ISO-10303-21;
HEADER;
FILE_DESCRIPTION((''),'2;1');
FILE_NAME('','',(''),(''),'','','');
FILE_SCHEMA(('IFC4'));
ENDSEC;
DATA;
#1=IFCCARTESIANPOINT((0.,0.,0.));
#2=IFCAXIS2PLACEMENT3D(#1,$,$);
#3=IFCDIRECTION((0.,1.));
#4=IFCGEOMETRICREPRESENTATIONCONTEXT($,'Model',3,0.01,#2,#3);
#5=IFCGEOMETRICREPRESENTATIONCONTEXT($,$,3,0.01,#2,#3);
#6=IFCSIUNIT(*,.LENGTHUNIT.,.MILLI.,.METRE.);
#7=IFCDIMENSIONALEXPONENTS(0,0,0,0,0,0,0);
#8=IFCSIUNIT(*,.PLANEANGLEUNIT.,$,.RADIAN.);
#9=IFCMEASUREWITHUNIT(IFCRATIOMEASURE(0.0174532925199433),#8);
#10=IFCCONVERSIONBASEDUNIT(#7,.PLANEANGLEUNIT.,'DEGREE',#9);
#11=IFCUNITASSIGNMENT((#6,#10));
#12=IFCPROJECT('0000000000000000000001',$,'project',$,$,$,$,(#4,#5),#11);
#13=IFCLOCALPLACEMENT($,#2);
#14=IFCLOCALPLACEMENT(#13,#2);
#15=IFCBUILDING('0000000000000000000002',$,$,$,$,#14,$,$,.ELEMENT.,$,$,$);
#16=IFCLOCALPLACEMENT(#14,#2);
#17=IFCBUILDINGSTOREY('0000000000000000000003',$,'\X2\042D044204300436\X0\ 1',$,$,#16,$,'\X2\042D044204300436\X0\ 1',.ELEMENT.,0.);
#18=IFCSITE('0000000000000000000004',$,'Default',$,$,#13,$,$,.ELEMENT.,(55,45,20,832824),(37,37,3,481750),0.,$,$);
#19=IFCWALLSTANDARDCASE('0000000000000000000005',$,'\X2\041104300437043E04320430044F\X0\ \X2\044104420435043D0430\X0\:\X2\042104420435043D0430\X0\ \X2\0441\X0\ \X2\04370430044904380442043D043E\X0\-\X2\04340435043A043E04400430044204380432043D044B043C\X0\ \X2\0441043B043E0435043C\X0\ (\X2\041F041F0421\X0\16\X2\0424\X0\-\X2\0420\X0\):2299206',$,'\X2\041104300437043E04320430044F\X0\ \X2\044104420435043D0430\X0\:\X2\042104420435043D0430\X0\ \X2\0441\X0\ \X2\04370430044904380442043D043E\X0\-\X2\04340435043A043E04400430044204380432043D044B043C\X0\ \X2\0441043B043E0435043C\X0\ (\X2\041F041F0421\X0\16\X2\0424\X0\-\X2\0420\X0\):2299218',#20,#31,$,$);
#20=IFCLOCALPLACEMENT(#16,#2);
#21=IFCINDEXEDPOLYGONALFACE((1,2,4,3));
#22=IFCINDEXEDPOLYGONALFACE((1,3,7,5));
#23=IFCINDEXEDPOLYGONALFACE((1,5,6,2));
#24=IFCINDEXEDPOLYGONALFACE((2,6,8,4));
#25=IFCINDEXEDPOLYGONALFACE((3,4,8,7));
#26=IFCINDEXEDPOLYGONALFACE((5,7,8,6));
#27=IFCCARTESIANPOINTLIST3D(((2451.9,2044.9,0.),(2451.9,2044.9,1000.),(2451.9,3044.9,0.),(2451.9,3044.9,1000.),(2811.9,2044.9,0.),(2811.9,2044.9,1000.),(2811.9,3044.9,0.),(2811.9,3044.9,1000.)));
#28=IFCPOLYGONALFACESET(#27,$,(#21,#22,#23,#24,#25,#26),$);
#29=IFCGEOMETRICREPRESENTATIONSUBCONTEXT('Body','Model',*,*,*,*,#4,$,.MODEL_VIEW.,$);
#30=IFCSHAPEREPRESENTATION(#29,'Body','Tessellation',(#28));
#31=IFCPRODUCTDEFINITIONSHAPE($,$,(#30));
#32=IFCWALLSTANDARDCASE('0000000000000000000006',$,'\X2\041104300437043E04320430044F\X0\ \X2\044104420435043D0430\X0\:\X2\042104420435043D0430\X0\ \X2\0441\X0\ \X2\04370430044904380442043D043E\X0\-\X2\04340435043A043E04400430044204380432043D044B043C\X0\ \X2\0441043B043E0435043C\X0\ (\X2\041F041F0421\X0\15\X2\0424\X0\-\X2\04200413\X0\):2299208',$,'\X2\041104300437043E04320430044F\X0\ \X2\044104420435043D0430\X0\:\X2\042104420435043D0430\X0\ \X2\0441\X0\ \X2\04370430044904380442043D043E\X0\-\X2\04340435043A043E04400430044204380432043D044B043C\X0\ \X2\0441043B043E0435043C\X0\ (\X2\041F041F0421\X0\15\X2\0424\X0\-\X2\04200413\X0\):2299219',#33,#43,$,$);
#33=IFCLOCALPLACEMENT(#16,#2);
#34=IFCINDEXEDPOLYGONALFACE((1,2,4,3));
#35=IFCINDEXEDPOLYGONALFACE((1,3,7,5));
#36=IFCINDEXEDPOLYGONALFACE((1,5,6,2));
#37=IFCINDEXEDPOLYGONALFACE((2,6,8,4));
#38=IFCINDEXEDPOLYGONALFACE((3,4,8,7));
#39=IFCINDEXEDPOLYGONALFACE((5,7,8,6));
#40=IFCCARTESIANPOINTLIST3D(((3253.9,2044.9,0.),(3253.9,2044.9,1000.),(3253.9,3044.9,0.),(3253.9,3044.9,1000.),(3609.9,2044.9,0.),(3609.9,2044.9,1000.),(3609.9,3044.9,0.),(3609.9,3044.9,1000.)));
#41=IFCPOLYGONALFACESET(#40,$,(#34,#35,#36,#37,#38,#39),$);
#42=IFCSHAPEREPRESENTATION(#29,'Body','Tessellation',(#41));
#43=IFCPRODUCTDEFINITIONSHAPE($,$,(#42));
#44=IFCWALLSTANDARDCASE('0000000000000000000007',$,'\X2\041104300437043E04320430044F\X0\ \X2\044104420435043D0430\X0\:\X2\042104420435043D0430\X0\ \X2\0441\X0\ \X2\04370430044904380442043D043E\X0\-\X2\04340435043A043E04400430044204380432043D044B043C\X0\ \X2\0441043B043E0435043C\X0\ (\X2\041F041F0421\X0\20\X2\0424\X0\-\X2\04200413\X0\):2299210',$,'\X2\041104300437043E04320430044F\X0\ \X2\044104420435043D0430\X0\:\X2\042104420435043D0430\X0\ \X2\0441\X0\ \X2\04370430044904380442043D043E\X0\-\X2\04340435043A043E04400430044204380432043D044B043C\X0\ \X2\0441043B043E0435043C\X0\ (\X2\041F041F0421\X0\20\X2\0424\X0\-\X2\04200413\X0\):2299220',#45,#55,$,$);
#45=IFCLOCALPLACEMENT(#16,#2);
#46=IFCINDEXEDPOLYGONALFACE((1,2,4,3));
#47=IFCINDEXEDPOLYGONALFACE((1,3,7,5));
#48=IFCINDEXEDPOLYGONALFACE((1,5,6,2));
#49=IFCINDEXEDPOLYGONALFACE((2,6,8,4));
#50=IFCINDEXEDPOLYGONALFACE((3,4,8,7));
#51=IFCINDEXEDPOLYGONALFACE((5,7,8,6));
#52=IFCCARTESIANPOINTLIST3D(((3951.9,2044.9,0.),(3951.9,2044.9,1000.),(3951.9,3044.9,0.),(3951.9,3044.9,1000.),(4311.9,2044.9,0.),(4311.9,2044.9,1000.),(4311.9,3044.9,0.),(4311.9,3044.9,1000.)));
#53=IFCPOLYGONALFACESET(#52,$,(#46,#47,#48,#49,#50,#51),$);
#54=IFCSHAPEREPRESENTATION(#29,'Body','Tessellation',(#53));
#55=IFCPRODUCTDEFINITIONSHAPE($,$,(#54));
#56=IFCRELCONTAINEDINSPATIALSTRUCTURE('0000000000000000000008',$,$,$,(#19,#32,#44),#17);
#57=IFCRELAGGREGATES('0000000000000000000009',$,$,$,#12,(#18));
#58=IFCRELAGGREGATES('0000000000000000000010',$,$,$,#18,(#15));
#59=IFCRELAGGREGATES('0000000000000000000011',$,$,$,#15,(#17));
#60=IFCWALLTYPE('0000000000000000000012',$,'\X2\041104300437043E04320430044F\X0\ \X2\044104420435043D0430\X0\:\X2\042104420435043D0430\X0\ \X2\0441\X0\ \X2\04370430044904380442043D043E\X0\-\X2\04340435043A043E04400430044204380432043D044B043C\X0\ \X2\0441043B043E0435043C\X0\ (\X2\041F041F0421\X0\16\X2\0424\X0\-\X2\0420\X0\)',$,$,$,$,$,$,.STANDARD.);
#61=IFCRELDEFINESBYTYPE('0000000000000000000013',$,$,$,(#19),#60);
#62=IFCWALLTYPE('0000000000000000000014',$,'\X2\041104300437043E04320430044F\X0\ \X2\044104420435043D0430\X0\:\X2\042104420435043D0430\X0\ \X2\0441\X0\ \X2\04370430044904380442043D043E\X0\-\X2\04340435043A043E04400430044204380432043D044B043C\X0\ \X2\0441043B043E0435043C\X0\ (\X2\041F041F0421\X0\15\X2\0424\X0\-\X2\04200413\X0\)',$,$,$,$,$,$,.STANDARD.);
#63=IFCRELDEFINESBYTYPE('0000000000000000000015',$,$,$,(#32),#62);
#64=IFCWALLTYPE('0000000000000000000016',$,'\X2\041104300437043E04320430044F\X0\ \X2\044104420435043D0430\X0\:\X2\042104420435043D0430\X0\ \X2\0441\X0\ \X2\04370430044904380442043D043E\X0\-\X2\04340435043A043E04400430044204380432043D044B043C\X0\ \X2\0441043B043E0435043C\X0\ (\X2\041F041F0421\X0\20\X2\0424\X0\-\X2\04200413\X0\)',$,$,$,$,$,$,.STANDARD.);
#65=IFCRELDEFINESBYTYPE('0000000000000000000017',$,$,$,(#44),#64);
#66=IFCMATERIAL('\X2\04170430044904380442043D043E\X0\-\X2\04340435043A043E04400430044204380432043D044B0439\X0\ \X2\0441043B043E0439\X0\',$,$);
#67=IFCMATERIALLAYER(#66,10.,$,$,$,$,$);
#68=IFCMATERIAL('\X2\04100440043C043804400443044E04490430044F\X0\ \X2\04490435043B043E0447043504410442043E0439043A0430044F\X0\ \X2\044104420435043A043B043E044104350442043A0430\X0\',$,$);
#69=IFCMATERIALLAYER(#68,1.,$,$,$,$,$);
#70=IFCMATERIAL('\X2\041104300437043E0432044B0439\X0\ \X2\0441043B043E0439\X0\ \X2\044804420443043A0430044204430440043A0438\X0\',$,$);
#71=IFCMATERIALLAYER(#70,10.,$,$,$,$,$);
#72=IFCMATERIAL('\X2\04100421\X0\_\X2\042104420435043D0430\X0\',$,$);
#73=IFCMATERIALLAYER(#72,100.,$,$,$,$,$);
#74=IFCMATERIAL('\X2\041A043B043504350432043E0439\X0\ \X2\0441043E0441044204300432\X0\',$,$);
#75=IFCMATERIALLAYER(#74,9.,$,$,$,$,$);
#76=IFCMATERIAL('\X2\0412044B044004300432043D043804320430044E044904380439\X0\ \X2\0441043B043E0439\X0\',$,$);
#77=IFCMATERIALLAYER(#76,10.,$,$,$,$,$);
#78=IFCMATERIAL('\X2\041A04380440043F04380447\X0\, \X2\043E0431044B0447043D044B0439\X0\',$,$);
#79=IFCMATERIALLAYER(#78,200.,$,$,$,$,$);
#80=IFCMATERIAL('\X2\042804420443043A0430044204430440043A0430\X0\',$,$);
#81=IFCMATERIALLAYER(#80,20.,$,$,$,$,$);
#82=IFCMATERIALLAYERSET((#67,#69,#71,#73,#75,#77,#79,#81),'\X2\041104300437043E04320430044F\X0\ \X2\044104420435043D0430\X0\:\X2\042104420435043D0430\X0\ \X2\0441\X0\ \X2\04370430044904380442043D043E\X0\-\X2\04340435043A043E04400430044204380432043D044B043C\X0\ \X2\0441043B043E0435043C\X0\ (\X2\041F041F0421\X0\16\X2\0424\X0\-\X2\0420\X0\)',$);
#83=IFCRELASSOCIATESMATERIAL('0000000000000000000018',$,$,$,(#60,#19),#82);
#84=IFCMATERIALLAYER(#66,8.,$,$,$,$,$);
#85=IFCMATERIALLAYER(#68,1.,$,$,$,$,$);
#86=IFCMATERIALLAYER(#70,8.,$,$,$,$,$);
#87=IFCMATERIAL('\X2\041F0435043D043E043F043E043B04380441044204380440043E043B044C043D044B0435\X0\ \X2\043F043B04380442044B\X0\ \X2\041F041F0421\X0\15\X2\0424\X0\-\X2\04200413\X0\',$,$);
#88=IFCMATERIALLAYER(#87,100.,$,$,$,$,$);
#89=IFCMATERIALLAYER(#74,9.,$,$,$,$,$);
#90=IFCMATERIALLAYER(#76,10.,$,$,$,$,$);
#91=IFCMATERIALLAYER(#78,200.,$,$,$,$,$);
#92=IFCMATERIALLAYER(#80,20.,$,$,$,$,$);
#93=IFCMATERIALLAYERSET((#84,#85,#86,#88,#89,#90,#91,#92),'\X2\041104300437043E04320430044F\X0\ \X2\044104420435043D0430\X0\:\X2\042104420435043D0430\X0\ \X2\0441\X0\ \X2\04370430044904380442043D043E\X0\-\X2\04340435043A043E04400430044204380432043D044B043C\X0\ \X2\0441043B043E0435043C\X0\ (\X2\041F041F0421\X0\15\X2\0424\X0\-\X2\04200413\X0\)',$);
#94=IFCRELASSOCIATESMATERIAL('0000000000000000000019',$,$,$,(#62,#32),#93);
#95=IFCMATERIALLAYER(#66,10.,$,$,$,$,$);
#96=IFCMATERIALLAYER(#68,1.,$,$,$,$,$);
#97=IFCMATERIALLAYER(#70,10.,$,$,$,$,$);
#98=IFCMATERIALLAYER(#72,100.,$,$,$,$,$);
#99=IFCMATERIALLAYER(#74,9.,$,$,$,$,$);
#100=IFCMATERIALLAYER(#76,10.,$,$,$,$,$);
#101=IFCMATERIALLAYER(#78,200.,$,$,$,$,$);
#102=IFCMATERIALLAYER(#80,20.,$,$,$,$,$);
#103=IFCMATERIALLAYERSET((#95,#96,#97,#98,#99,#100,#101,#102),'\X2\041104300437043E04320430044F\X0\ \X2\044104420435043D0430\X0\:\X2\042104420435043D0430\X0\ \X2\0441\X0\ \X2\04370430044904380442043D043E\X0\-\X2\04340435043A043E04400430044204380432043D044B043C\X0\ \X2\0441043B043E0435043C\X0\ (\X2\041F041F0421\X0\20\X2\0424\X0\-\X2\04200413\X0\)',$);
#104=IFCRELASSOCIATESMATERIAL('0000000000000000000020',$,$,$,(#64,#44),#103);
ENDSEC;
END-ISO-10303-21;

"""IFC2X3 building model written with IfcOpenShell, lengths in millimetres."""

from ifc_helpers import new_model, entity, si_unit, converted_unit, direction, frame, frame_2d, origin, place, context, subcontext, project, spatial, rectangle, extrude, material, layer, layer_set, layer_usage, type_object, element, save


model = new_model("IFC2X3")

# Units and contexts
model_context = context("Model", 3, precision=0.01, world=origin(), true_north=direction((0.0, 1.0)))
context_of_model = context(None, 3, precision=0.01, world=origin(), true_north=direction((0.0, 1.0)))
body_context = subcontext(model_context, "Body", "Model", "MODEL_VIEW")
ifc_project = project(units=[si_unit("LENGTHUNIT", "METRE", prefix="MILLI"), converted_unit("PLANEANGLEUNIT", "DEGREE", entity("IfcRatioMeasure", 0.0174532925199433), si_unit("PLANEANGLEUNIT", "RADIAN"), dimensions=[0, 0, 0, 0, 0, 0, 0])], contexts=[model_context, context_of_model])

# Site, building, storey
site_placement = place(None, origin())
site = spatial("IfcSite", under=ifc_project, at=site_placement, Name="Default", CompositionType="ELEMENT", RefLatitude=(55, 45, 20, 832824), RefLongitude=(37, 37, 3, 481750), RefElevation=0.0)
building_placement = place(site_placement, origin())
building = spatial("IfcBuilding", under=site, at=building_placement, CompositionType="ELEMENT")
storey_placement = place(building_placement, origin())
storey = spatial("IfcBuildingStorey", under=building, at=storey_placement, Name="Этаж 1", LongName="Этаж 1", CompositionType="ELEMENT", Elevation=0.0)

# Walls
ifc_material_1 = material(Name="Защитно-декоративный слой")
ifc_layer_1 = layer(ifc_material_1, 10.0)
ifc_material_2 = material(Name="Армирующая щелочестойкая стеклосетка")
ifc_layer_2 = layer(ifc_material_2, 1.0)
ifc_material_3 = material(Name="Базовый слой штукатурки")
ifc_layer_3 = layer(ifc_material_3, 10.0)
ifc_material_4 = material(Name="АС_Стена")
ifc_layer_4 = layer(ifc_material_4, 100.0)
ifc_material_5 = material(Name="Клеевой состав")
ifc_layer_5 = layer(ifc_material_5, 9.0)
ifc_material_6 = material(Name="Выравнивающий слой")
ifc_layer_6 = layer(ifc_material_6, 10.0)
ifc_material_7 = material(Name="Кирпич, обычный")
ifc_layer_7 = layer(ifc_material_7, 200.0)
ifc_material_8 = material(Name="Штукатурка")
ifc_layer_8 = layer(ifc_material_8, 20.0)
ifc_layer_set_1 = layer_set([ifc_layer_1, ifc_layer_2, ifc_layer_3, ifc_layer_4, ifc_layer_5, ifc_layer_6, ifc_layer_7, ifc_layer_8], Name="Базовая стена:Стена с защитно-декоративным слоем (ППС16Ф-Р)")
ifc_layer_usage_1 = layer_usage(ifc_layer_set_1, "AXIS2", "POSITIVE", -180.0)
wall_type_1 = type_object("IfcWallType", Name="Базовая стена:Стена с защитно-декоративным слоем (ППС16Ф-Р)", PredefinedType="STANDARD", material=ifc_layer_set_1)
wall_1_placement = place(storey_placement, frame((2631.9, 3044.9, 0.0), z_axis=(0.0, 0.0, 1.0), x_axis=(0.0, -1.0, 0.0)))
element("IfcWallStandardCase", 1, at=wall_1_placement, inside=storey, type_object=wall_type_1, material=ifc_layer_usage_1, Name="Базовая стена:Стена с защитно-декоративным слоем (ППС16Ф-Р):2299206", ObjectType="Базовая стена:Стена с защитно-декоративным слоем (ППС16Ф-Р):2299218", context=body_context, shape_type="SweptSolid", body=[
    extrude(rectangle(XDim=1000.0, YDim=360.0, at=frame_2d((500.0, 0.0), x_axis=(-1.0, 0.0))), origin(), (0.0, 0.0, 1.0), 1000.0),
])
ifc_layer_9 = layer(ifc_material_1, 8.0)
ifc_layer_10 = layer(ifc_material_2, 1.0)
ifc_layer_11 = layer(ifc_material_3, 8.0)
ifc_material_9 = material(Name="Пенополистирольные плиты ППС15Ф-РГ")
ifc_layer_12 = layer(ifc_material_9, 100.0)
ifc_layer_13 = layer(ifc_material_5, 9.0)
ifc_layer_14 = layer(ifc_material_6, 10.0)
ifc_layer_15 = layer(ifc_material_7, 200.0)
ifc_layer_16 = layer(ifc_material_8, 20.0)
ifc_layer_set_2 = layer_set([ifc_layer_9, ifc_layer_10, ifc_layer_11, ifc_layer_12, ifc_layer_13, ifc_layer_14, ifc_layer_15, ifc_layer_16], Name="Базовая стена:Стена с защитно-декоративным слоем (ППС15Ф-РГ)")
ifc_layer_usage_2 = layer_usage(ifc_layer_set_2, "AXIS2", "POSITIVE", -178.0)
wall_type_2 = type_object("IfcWallType", Name="Базовая стена:Стена с защитно-декоративным слоем (ППС15Ф-РГ)", PredefinedType="STANDARD", material=ifc_layer_set_2)
wall_2_placement = place(storey_placement, frame((3431.9, 3044.9, 0.0), z_axis=(0.0, 0.0, 1.0), x_axis=(0.0, -1.0, 0.0)))
element("IfcWallStandardCase", 2, at=wall_2_placement, inside=storey, type_object=wall_type_2, material=ifc_layer_usage_2, Name="Базовая стена:Стена с защитно-декоративным слоем (ППС15Ф-РГ):2299208", ObjectType="Базовая стена:Стена с защитно-декоративным слоем (ППС15Ф-РГ):2299219", context=body_context, shape_type="SweptSolid", body=[
    extrude(rectangle(XDim=1000.0, YDim=356.0, at=frame_2d((500.0, 0.0), x_axis=(-1.0, 0.0))), origin(), (0.0, 0.0, 1.0), 1000.0),
])
ifc_layer_17 = layer(ifc_material_1, 10.0)
ifc_layer_18 = layer(ifc_material_2, 1.0)
ifc_layer_19 = layer(ifc_material_3, 10.0)
ifc_layer_20 = layer(ifc_material_4, 100.0)
ifc_layer_21 = layer(ifc_material_5, 9.0)
ifc_layer_22 = layer(ifc_material_6, 10.0)
ifc_layer_23 = layer(ifc_material_7, 200.0)
ifc_layer_24 = layer(ifc_material_8, 20.0)
ifc_layer_set_3 = layer_set([ifc_layer_17, ifc_layer_18, ifc_layer_19, ifc_layer_20, ifc_layer_21, ifc_layer_22, ifc_layer_23, ifc_layer_24], Name="Базовая стена:Стена с защитно-декоративным слоем (ППС20Ф-РГ)")
ifc_layer_usage_3 = layer_usage(ifc_layer_set_3, "AXIS2", "POSITIVE", -180.0)
wall_type_3 = type_object("IfcWallType", Name="Базовая стена:Стена с защитно-декоративным слоем (ППС20Ф-РГ)", PredefinedType="STANDARD", material=ifc_layer_set_3)
wall_3_placement = place(storey_placement, frame((4131.9, 3044.9, 0.0), z_axis=(0.0, 0.0, 1.0), x_axis=(0.0, -1.0, 0.0)))
element("IfcWallStandardCase", 3, at=wall_3_placement, inside=storey, type_object=wall_type_3, material=ifc_layer_usage_3, Name="Базовая стена:Стена с защитно-декоративным слоем (ППС20Ф-РГ):2299210", ObjectType="Базовая стена:Стена с защитно-декоративным слоем (ППС20Ф-РГ):2299220", context=body_context, shape_type="SweptSolid", body=[
    extrude(rectangle(XDim=1000.0, YDim=360.0, at=frame_2d((500.0, 0.0), x_axis=(-1.0, 0.0))), origin(), (0.0, 0.0, 1.0), 1000.0),
])

save(model, "model.ifc")
